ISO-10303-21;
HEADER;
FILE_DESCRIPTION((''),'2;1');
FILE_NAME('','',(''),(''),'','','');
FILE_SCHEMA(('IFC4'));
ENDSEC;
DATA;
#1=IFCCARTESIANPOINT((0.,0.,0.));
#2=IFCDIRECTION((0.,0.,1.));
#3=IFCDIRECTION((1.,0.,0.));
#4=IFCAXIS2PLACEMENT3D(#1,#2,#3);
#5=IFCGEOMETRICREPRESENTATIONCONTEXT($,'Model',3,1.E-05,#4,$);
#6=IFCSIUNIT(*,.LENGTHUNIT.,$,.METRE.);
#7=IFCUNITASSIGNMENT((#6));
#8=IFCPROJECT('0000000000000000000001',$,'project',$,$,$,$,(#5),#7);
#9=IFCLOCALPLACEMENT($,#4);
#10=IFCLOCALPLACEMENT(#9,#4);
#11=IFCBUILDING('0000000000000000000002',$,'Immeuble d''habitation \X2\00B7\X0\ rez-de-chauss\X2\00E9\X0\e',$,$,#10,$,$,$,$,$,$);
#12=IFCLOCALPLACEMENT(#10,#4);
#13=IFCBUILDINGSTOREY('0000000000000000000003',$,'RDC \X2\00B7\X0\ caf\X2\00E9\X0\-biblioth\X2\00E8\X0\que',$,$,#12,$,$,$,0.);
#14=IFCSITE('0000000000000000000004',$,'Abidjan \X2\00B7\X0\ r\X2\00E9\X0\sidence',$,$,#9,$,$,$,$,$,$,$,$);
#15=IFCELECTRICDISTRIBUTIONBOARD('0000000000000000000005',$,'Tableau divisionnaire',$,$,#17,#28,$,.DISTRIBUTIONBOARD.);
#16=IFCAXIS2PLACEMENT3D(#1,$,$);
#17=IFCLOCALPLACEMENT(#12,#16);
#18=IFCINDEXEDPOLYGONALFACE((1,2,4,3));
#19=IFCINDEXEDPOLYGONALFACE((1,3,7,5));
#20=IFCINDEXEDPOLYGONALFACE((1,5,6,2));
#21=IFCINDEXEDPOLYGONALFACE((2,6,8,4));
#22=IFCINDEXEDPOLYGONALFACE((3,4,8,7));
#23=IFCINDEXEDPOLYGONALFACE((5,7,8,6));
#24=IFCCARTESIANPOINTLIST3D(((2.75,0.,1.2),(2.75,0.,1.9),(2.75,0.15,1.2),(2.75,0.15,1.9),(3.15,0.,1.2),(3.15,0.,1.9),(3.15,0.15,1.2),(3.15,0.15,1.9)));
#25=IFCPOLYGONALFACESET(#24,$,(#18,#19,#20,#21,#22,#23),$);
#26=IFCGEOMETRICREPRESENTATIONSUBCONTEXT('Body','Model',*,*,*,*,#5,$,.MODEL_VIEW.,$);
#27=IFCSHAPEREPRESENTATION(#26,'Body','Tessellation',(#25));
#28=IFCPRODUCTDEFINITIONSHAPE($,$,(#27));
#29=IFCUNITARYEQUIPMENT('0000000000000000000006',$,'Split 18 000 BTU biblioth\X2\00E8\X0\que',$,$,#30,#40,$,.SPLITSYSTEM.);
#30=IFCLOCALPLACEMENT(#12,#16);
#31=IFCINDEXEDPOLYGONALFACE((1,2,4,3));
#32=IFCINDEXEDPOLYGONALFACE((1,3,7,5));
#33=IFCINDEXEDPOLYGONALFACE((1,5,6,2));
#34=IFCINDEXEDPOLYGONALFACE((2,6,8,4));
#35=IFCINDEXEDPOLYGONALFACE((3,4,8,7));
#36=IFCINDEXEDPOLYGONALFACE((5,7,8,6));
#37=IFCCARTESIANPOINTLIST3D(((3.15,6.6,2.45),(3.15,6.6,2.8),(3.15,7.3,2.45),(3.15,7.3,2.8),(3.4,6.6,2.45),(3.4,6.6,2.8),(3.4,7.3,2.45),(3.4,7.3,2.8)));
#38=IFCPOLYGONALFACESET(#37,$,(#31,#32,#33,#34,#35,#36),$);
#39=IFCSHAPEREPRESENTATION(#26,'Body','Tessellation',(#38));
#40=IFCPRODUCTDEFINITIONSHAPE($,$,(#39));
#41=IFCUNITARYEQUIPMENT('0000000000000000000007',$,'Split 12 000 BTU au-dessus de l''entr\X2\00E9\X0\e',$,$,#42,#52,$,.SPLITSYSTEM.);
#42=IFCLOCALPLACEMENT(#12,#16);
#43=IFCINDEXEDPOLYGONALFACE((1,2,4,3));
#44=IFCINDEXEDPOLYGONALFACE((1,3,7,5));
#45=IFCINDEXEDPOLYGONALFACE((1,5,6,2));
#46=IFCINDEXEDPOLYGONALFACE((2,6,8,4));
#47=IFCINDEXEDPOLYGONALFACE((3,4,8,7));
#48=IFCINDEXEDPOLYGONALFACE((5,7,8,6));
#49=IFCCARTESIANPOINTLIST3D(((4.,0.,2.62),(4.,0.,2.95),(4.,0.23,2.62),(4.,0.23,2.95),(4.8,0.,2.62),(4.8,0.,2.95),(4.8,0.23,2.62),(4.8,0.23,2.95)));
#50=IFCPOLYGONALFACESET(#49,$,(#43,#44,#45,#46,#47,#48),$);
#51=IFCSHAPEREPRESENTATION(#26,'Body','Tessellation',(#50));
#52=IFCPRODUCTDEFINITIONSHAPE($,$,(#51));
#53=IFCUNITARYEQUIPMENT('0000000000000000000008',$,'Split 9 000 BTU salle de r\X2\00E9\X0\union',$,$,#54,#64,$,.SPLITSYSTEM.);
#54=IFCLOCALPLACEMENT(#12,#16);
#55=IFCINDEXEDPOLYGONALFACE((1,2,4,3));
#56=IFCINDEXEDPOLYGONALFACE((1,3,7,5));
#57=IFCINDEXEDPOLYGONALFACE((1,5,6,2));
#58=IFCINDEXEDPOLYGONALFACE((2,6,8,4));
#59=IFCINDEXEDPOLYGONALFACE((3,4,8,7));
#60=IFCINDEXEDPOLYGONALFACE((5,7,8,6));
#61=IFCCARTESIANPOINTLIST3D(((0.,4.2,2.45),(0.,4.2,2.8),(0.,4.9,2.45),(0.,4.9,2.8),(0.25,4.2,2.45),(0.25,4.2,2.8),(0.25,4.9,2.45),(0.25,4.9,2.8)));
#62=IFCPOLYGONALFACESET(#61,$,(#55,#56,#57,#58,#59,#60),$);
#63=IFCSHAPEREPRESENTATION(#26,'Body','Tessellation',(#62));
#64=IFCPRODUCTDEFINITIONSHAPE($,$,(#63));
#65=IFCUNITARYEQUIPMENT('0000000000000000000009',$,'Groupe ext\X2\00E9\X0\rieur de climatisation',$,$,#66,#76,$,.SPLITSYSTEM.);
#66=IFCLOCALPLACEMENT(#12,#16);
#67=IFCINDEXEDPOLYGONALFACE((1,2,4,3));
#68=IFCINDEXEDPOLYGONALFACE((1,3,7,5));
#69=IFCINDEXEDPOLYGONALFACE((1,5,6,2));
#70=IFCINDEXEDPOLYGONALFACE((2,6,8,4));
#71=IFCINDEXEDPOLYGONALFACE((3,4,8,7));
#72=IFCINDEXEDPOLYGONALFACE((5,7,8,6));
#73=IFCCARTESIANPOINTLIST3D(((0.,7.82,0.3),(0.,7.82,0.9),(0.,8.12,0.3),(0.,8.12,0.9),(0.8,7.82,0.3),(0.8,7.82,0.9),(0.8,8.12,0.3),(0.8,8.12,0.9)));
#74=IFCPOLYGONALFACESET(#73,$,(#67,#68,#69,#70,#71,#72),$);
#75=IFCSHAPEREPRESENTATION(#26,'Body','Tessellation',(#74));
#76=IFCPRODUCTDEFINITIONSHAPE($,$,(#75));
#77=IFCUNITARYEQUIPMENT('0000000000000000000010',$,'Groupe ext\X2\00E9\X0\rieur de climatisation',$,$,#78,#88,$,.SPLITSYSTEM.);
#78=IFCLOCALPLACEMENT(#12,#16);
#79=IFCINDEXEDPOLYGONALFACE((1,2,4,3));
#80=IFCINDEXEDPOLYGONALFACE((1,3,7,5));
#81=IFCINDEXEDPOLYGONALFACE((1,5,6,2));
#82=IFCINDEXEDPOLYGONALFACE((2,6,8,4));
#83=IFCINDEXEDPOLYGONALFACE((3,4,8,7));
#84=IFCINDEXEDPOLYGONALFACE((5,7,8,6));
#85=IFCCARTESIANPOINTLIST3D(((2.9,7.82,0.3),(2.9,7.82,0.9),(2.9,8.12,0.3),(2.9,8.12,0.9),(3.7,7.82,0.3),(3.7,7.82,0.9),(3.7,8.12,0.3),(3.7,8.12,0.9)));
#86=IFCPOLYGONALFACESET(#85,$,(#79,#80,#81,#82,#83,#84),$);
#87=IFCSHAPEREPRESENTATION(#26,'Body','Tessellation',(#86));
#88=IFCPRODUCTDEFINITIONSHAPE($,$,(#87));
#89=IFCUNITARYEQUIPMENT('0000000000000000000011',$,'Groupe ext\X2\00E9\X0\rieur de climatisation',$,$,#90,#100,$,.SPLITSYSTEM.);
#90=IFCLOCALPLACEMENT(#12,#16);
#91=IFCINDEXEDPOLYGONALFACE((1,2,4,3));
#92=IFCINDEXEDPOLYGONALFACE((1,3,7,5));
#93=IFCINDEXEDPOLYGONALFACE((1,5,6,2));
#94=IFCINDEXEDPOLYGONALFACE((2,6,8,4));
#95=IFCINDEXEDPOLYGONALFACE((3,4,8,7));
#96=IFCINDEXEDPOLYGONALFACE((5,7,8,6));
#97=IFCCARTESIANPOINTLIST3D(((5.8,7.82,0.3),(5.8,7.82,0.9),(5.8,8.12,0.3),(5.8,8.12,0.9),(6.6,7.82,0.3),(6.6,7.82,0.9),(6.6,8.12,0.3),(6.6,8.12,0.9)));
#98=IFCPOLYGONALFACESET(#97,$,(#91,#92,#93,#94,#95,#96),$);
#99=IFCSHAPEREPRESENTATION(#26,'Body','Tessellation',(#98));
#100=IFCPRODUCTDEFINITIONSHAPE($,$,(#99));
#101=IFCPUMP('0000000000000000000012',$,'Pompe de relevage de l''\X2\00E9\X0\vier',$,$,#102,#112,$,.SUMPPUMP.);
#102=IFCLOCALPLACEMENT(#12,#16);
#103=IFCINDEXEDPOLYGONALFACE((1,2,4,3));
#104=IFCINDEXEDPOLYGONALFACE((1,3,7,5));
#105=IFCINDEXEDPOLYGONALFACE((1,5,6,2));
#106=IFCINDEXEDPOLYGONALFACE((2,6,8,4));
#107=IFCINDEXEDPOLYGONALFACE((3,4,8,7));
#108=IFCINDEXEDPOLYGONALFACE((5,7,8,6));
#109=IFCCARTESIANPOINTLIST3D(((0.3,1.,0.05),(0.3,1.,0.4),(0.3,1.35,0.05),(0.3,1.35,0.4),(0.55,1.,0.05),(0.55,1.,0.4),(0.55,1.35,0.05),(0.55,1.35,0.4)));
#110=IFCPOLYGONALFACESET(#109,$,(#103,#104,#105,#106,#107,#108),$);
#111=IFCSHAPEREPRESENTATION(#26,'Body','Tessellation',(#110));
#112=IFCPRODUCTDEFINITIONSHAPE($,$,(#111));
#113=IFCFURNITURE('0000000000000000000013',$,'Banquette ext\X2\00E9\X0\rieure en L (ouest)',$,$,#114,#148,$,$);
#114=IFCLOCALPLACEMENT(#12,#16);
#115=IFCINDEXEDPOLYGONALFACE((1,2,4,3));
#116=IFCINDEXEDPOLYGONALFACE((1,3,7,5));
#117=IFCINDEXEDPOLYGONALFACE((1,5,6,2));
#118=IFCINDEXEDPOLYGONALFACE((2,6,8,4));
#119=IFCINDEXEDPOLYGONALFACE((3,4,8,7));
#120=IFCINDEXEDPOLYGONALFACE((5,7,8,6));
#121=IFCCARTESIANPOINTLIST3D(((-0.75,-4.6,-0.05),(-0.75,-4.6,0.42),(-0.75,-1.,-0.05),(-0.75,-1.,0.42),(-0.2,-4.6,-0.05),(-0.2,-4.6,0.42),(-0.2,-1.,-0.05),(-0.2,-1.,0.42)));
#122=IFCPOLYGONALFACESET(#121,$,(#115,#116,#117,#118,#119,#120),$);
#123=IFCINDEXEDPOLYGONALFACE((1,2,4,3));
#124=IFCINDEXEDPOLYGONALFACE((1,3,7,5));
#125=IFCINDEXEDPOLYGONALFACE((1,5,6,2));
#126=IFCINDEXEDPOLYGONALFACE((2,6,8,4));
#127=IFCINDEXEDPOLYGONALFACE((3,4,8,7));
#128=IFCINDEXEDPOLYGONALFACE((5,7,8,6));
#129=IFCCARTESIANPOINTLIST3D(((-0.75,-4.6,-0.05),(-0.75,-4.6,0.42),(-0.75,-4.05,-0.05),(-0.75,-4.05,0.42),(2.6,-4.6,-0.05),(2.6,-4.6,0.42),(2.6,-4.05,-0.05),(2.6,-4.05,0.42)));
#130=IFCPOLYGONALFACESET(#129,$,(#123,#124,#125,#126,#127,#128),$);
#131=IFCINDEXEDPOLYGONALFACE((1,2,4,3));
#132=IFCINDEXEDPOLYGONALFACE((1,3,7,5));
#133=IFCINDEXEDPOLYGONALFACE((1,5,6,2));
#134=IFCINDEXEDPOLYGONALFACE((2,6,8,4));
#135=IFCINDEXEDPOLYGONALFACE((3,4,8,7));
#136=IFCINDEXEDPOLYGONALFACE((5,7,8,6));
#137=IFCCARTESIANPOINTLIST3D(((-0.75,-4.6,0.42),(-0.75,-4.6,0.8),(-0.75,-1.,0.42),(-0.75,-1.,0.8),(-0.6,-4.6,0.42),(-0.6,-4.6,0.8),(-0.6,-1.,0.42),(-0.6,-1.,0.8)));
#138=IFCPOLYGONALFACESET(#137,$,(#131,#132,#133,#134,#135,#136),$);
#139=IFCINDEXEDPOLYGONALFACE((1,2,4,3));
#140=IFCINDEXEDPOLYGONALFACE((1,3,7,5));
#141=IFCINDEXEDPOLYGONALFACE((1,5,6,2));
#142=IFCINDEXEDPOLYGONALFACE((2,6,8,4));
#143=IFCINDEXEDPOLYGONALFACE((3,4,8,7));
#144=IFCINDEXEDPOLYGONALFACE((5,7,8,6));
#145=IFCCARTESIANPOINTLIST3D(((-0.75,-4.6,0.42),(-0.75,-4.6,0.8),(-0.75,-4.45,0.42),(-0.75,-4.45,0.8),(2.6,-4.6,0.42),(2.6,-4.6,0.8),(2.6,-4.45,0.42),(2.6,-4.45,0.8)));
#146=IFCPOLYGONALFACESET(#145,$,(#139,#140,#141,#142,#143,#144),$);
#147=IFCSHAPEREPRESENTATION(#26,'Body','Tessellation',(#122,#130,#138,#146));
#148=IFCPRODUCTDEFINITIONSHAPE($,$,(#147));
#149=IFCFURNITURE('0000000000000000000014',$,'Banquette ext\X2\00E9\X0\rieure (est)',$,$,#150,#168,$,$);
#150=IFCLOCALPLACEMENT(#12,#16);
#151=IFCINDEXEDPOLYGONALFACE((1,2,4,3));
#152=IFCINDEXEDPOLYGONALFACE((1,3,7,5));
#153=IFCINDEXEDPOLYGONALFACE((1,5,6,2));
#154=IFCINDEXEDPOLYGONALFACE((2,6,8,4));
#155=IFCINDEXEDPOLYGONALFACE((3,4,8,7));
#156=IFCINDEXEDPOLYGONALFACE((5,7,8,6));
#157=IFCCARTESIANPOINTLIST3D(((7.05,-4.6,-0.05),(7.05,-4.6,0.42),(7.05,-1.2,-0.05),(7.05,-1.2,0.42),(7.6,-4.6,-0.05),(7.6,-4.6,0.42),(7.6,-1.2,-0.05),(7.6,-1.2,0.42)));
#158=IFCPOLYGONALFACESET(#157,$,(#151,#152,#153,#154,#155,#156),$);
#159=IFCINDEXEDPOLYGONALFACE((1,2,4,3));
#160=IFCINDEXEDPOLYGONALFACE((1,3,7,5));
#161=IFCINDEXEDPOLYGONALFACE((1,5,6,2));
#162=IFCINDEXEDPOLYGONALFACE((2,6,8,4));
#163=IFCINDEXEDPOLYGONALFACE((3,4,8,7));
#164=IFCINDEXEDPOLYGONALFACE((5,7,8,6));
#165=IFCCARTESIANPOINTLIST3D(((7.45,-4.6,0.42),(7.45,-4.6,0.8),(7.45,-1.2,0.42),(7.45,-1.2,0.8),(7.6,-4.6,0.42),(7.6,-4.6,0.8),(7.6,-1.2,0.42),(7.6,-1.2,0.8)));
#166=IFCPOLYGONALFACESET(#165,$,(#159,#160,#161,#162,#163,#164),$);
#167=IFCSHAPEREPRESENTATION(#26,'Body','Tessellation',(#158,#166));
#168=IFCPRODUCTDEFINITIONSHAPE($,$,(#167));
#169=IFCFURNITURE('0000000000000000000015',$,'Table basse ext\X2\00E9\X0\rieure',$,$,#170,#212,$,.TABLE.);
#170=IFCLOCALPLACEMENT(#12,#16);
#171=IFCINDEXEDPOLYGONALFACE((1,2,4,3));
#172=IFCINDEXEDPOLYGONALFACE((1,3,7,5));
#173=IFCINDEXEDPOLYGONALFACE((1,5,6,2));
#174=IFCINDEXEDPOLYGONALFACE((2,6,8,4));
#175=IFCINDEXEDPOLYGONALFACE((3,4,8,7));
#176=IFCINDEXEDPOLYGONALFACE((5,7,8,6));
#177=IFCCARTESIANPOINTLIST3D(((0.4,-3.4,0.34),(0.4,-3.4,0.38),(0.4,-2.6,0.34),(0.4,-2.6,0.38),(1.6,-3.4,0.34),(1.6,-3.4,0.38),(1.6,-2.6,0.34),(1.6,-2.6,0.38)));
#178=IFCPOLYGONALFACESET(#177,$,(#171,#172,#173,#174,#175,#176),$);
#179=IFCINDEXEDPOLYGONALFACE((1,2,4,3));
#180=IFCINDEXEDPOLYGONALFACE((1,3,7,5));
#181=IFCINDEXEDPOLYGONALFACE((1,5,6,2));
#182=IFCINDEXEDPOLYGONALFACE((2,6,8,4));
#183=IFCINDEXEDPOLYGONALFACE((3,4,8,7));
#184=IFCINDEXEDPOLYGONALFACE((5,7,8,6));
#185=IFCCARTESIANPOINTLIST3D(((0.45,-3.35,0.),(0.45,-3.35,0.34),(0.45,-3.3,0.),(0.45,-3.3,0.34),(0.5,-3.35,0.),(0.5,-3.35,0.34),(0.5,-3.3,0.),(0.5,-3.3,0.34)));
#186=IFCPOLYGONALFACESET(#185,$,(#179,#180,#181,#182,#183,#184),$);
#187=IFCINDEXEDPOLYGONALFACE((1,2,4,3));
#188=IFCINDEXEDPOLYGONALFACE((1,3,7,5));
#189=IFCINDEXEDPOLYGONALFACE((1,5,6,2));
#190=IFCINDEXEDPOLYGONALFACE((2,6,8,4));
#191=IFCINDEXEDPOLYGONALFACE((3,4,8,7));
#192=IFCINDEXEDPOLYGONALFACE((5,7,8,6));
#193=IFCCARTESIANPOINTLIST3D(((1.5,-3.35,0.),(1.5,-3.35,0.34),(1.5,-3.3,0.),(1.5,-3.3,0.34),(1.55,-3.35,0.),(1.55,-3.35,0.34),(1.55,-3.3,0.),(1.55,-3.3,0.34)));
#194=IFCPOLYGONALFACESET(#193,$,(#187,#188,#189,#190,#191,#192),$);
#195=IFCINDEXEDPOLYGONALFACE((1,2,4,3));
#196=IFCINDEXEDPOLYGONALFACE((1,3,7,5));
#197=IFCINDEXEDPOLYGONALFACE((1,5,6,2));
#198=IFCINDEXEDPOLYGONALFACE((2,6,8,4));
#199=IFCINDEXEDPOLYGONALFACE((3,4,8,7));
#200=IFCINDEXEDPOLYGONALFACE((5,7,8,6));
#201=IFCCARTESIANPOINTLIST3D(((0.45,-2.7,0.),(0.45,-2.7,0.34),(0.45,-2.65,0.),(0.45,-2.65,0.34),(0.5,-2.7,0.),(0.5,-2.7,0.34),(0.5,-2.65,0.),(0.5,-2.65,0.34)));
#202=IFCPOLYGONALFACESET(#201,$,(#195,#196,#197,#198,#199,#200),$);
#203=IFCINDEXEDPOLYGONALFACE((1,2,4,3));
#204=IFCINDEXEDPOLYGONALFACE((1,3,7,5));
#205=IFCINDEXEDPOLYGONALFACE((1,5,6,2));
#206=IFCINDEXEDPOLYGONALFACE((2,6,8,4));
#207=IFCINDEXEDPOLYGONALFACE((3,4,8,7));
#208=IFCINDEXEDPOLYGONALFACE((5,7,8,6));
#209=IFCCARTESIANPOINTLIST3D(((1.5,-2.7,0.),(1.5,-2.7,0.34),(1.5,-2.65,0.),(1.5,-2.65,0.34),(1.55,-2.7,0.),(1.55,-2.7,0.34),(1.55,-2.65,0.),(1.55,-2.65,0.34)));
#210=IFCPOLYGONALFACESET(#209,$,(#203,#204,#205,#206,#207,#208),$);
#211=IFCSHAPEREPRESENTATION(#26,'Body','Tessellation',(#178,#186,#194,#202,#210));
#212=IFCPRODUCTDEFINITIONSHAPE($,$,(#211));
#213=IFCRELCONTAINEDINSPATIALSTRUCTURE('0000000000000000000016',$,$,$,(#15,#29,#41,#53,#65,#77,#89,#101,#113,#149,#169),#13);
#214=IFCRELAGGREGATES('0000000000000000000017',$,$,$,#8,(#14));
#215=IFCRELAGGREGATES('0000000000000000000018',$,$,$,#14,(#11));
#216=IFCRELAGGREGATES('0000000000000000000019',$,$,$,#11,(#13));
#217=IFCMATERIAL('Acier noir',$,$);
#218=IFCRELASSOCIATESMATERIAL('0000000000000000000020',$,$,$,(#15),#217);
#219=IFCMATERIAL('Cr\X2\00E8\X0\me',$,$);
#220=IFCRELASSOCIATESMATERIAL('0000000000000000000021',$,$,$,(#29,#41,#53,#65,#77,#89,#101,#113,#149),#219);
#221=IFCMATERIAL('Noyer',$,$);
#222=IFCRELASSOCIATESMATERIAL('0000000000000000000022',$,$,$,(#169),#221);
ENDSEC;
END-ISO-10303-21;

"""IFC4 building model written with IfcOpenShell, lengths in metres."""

from ifc_helpers import new_model, si_unit, frame, frame_2d, origin, origin_with_axes, place, context, subcontext, project, spatial, rectangle, extrude, material, element, save


model = new_model("IFC4")

# Units and contexts
model_context = context("Model", 3, precision=1e-05, world=origin_with_axes())
body_context = subcontext(model_context, "Body", "Model", "MODEL_VIEW")
ifc_project = project(units=[si_unit("LENGTHUNIT", "METRE")], contexts=[model_context])

# Site, building, storey
site_placement = place(None, origin_with_axes())
site = spatial("IfcSite", under=ifc_project, at=site_placement, Name="Abidjan · résidence")
building_placement = place(site_placement, origin_with_axes())
building = spatial("IfcBuilding", under=site, at=building_placement, Name="Immeuble d'habitation · rez-de-chaussée")
storey_placement = place(building_placement, origin_with_axes())
storey = spatial("IfcBuildingStorey", under=building, at=storey_placement, Name="RDC · café-bibliothèque", Elevation=0.0)

# Electric distribution board
ifc_material_1 = material(Name="Acier noir")
electric_distribution_board_placement = place(storey_placement, origin_with_axes())
element("IfcElectricDistributionBoard", 1, at=electric_distribution_board_placement, inside=storey, material=ifc_material_1, Name="Tableau divisionnaire", PredefinedType="DISTRIBUTIONBOARD", context=body_context, shape_type="SweptSolid", body=[
    extrude(rectangle(XDim=0.4, YDim=0.15, at=frame_2d((2.95, 0.075))), frame((0.0, 0.0, 1.2)), (0.0, 0.0, 1.0), 0.7),
])

# Unitary equipment
ifc_material_2 = material(Name="Crème")
unitary_equipment_1_placement = place(storey_placement, origin_with_axes())
element("IfcUnitaryEquipment", 2, at=unitary_equipment_1_placement, inside=storey, material=ifc_material_2, Name="Split 18 000 BTU bibliothèque", PredefinedType="SPLITSYSTEM", context=body_context, shape_type="SweptSolid", body=[
    extrude(rectangle(XDim=0.25, YDim=0.7, at=frame_2d((3.275, 6.95))), frame((0.0, 0.0, 2.45)), (0.0, 0.0, 1.0), 0.35),
])
unitary_equipment_2_placement = place(storey_placement, origin_with_axes())
element("IfcUnitaryEquipment", 3, at=unitary_equipment_2_placement, inside=storey, material=ifc_material_2, Name="Split 12 000 BTU au-dessus de l'entrée", PredefinedType="SPLITSYSTEM", context=body_context, shape_type="SweptSolid", body=[
    extrude(rectangle(XDim=0.8, YDim=0.23, at=frame_2d((4.4, 0.115))), frame((0.0, 0.0, 2.62)), (0.0, 0.0, 1.0), 0.33),
])
unitary_equipment_3_placement = place(storey_placement, origin_with_axes())
element("IfcUnitaryEquipment", 4, at=unitary_equipment_3_placement, inside=storey, material=ifc_material_2, Name="Split 9 000 BTU salle de réunion", PredefinedType="SPLITSYSTEM", context=body_context, shape_type="SweptSolid", body=[
    extrude(rectangle(XDim=0.25, YDim=0.7, at=frame_2d((0.125, 4.55))), frame((0.0, 0.0, 2.45)), (0.0, 0.0, 1.0), 0.35),
])
unitary_equipment_4_placement = place(storey_placement, origin_with_axes())
element("IfcUnitaryEquipment", 5, at=unitary_equipment_4_placement, inside=storey, material=ifc_material_2, Name="Groupe extérieur de climatisation", PredefinedType="SPLITSYSTEM", context=body_context, shape_type="SweptSolid", body=[
    extrude(rectangle(XDim=0.8, YDim=0.3, at=frame_2d((0.4, 7.97))), frame((0.0, 0.0, 0.3)), (0.0, 0.0, 1.0), 0.6),
])
unitary_equipment_5_placement = place(storey_placement, origin_with_axes())
element("IfcUnitaryEquipment", 6, at=unitary_equipment_5_placement, inside=storey, material=ifc_material_2, Name="Groupe extérieur de climatisation", PredefinedType="SPLITSYSTEM", context=body_context, shape_type="SweptSolid", body=[
    extrude(rectangle(XDim=0.8, YDim=0.3, at=frame_2d((3.3, 7.97))), frame((0.0, 0.0, 0.3)), (0.0, 0.0, 1.0), 0.6),
])
unitary_equipment_6_placement = place(storey_placement, origin_with_axes())
element("IfcUnitaryEquipment", 7, at=unitary_equipment_6_placement, inside=storey, material=ifc_material_2, Name="Groupe extérieur de climatisation", PredefinedType="SPLITSYSTEM", context=body_context, shape_type="SweptSolid", body=[
    extrude(rectangle(XDim=0.8, YDim=0.3, at=frame_2d((6.2, 7.97))), frame((0.0, 0.0, 0.3)), (0.0, 0.0, 1.0), 0.6),
])

# Pump
pump_placement = place(storey_placement, origin_with_axes())
element("IfcPump", 8, at=pump_placement, inside=storey, material=ifc_material_2, Name="Pompe de relevage de l'évier", PredefinedType="SUMPPUMP", context=body_context, shape_type="SweptSolid", body=[
    extrude(rectangle(XDim=0.25, YDim=0.35, at=frame_2d((0.425, 1.175))), frame((0.0, 0.0, 0.05)), (0.0, 0.0, 1.0), 0.35),
])

# Furniture
furniture_1_placement = place(storey_placement, origin_with_axes())
element("IfcFurniture", 9, at=furniture_1_placement, inside=storey, material=ifc_material_2, Name="Banquette extérieure en L (ouest)", context=body_context, shape_type="SweptSolid", body=[
    extrude(rectangle(XDim=0.55, YDim=3.6, at=frame_2d((-0.475, -2.8))), frame((0.0, 0.0, -0.05)), (0.0, 0.0, 1.0), 0.47),
    extrude(rectangle(XDim=3.35, YDim=0.55, at=frame_2d((0.925, -4.325))), frame((0.0, 0.0, -0.05)), (0.0, 0.0, 1.0), 0.47),
    extrude(rectangle(XDim=0.15, YDim=3.6, at=frame_2d((-0.675, -2.8))), frame((0.0, 0.0, 0.42)), (0.0, 0.0, 1.0), 0.38),
    extrude(rectangle(XDim=3.35, YDim=0.15, at=frame_2d((0.925, -4.525))), frame((0.0, 0.0, 0.42)), (0.0, 0.0, 1.0), 0.38),
])
furniture_2_placement = place(storey_placement, origin_with_axes())
element("IfcFurniture", 10, at=furniture_2_placement, inside=storey, material=ifc_material_2, Name="Banquette extérieure (est)", context=body_context, shape_type="SweptSolid", body=[
    extrude(rectangle(XDim=0.55, YDim=3.4, at=frame_2d((7.325, -2.9))), frame((0.0, 0.0, -0.05)), (0.0, 0.0, 1.0), 0.47),
    extrude(rectangle(XDim=0.15, YDim=3.4, at=frame_2d((7.525, -2.9))), frame((0.0, 0.0, 0.42)), (0.0, 0.0, 1.0), 0.38),
])
ifc_material_3 = material(Name="Noyer")
furniture_3_placement = place(storey_placement, origin_with_axes())
element("IfcFurniture", 11, at=furniture_3_placement, inside=storey, material=ifc_material_3, Name="Table basse extérieure", PredefinedType="TABLE", context=body_context, shape_type="SweptSolid", body=[
    extrude(rectangle(XDim=1.2, YDim=0.8, at=frame_2d((1.0, -3.0))), frame((0.0, 0.0, 0.34)), (0.0, 0.0, 1.0), 0.04),
    extrude(rectangle(XDim=0.05, YDim=0.05, at=frame_2d((0.475, -3.325))), origin(), (0.0, 0.0, 1.0), 0.34),
    extrude(rectangle(XDim=0.05, YDim=0.05, at=frame_2d((1.525, -3.325))), origin(), (0.0, 0.0, 1.0), 0.34),
    extrude(rectangle(XDim=0.05, YDim=0.05, at=frame_2d((0.475, -2.675))), origin(), (0.0, 0.0, 1.0), 0.34),
    extrude(rectangle(XDim=0.05, YDim=0.05, at=frame_2d((1.525, -2.675))), origin(), (0.0, 0.0, 1.0), 0.34),
])

save(model, "model.ifc")
